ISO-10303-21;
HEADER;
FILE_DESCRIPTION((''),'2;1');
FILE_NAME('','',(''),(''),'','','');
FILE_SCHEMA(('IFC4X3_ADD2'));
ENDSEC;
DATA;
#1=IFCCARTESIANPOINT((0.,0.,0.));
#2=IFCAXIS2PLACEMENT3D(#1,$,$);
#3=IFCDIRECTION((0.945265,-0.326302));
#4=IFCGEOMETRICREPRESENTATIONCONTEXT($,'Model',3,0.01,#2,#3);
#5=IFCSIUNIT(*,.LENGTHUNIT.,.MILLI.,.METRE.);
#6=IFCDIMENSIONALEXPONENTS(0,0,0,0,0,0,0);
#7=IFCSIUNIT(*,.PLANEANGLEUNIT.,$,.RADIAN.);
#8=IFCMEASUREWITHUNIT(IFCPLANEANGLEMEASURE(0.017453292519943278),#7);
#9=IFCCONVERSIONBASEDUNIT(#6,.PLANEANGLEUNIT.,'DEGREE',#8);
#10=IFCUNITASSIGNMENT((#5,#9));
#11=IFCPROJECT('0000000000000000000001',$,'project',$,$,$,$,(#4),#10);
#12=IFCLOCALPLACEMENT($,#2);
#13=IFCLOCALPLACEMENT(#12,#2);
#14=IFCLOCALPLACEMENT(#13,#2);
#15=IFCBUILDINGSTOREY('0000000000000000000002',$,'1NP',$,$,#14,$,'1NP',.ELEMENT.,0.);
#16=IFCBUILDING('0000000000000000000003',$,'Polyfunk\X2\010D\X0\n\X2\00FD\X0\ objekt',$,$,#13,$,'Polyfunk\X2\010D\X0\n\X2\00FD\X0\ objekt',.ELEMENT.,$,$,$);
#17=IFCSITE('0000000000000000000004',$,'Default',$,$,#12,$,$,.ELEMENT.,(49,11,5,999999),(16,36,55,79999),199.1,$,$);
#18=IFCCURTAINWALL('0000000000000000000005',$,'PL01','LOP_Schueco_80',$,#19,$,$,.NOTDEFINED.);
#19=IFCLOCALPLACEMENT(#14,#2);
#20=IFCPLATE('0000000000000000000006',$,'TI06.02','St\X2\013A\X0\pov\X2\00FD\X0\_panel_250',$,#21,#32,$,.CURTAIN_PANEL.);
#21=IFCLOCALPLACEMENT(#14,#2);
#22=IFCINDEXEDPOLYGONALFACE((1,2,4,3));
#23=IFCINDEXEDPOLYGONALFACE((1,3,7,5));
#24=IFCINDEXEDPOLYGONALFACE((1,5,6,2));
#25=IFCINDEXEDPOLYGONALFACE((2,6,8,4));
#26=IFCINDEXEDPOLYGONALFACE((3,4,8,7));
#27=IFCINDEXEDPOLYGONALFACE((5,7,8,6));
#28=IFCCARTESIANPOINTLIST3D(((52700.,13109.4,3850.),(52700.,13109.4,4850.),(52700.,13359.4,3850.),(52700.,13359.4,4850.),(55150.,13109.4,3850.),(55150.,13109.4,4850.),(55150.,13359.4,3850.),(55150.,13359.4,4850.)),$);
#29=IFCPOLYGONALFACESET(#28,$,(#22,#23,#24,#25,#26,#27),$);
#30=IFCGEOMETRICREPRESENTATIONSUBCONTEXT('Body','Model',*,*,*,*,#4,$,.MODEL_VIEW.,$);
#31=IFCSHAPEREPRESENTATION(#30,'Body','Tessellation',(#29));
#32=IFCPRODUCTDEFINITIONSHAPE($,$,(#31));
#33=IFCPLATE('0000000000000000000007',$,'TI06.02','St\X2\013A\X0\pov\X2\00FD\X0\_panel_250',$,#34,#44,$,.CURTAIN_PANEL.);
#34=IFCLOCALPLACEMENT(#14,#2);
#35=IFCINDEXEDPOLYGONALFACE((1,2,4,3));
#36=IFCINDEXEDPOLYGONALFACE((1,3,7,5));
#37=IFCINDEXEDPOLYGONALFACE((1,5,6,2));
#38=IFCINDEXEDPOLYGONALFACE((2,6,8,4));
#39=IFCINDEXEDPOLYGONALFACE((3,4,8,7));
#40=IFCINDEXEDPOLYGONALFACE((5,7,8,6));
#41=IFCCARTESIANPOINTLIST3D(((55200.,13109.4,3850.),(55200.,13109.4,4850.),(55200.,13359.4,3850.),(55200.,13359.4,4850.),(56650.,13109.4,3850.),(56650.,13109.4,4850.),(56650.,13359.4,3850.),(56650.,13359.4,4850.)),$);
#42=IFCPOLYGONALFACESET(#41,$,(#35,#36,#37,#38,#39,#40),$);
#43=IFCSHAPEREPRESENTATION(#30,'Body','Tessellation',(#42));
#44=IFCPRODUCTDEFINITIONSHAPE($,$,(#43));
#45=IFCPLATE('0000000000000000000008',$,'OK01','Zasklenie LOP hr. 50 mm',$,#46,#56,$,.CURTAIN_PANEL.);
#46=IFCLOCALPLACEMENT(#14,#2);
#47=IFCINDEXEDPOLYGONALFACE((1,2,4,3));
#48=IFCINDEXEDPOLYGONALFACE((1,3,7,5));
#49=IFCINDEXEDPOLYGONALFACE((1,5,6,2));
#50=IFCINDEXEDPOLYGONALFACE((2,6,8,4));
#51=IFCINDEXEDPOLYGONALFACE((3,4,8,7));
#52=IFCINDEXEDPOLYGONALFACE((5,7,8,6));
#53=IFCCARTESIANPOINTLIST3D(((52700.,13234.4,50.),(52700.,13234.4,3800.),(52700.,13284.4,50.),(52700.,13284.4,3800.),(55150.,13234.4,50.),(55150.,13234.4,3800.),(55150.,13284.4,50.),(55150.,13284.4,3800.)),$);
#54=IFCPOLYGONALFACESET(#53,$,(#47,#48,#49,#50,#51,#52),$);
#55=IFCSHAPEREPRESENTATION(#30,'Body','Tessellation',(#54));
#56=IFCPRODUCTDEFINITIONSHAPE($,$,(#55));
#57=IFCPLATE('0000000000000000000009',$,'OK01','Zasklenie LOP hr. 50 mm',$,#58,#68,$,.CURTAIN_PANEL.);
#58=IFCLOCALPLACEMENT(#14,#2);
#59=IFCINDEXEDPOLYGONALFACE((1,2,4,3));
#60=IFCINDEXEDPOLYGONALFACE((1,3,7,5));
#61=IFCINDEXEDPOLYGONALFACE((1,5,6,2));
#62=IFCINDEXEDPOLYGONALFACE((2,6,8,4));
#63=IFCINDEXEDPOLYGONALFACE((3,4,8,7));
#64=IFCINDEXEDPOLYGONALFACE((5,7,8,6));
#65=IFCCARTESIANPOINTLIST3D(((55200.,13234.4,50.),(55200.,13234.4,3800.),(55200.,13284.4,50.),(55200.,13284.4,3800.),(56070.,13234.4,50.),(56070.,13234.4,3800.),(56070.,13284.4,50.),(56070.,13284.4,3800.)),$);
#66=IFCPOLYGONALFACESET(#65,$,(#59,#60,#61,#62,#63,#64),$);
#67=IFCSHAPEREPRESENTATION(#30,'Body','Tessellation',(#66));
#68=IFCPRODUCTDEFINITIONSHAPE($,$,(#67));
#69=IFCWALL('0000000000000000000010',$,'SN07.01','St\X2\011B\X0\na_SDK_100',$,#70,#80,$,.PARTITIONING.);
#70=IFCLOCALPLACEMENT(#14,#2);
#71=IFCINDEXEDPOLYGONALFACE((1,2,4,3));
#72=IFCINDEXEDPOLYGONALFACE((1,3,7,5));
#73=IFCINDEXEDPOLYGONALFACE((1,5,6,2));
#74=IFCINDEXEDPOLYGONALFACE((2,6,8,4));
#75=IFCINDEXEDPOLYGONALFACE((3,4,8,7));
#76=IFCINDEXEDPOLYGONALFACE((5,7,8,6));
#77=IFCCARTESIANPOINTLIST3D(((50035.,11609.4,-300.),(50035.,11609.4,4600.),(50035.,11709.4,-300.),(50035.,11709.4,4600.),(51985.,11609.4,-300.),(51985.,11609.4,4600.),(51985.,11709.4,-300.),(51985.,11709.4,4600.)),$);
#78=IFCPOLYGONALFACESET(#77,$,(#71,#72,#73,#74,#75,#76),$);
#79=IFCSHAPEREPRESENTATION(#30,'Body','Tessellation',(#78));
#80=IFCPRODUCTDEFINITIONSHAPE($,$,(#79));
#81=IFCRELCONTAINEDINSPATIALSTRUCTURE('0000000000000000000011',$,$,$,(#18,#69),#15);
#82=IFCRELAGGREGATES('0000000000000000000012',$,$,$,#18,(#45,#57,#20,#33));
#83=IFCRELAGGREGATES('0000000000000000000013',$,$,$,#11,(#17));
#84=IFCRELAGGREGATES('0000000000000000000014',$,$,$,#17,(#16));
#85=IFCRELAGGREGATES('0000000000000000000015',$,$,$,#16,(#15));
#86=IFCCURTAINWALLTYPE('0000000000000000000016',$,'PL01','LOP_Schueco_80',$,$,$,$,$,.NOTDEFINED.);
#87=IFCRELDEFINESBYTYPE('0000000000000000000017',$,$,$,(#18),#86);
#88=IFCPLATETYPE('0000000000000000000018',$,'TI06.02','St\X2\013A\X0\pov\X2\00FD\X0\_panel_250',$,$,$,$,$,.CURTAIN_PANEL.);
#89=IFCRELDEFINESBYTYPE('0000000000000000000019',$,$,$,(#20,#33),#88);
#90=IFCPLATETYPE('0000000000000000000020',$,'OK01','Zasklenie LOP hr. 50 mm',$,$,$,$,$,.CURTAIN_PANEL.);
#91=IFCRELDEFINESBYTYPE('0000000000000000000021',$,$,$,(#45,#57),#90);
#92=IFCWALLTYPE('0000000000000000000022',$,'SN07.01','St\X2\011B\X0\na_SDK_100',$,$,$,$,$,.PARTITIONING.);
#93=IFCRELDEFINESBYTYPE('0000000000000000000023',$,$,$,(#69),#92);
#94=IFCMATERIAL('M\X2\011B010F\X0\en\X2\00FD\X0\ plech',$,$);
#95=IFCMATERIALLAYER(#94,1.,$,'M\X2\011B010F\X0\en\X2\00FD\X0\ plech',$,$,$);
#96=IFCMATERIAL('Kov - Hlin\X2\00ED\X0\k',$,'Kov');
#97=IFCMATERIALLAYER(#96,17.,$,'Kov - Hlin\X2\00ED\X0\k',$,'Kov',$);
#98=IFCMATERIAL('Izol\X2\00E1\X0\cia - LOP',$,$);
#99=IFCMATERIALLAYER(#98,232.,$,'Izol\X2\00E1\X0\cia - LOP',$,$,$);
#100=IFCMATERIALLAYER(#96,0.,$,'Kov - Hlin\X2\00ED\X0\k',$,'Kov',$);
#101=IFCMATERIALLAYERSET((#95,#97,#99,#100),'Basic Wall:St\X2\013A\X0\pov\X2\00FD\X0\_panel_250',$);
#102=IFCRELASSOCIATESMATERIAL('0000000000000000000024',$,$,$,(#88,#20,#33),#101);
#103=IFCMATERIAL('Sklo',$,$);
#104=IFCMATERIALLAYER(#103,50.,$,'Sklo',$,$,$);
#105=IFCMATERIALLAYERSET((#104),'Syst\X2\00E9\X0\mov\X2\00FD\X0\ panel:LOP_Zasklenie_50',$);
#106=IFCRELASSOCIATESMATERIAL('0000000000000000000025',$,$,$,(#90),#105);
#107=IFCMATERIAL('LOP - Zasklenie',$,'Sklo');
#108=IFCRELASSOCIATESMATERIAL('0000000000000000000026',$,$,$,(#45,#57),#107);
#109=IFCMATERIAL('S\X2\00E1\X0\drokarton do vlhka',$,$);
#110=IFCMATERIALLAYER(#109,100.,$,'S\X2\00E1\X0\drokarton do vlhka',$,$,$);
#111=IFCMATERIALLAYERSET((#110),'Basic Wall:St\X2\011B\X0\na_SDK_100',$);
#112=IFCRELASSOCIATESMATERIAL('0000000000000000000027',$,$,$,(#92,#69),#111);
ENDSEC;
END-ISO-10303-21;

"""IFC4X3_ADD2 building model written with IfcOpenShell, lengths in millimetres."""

from ifc_helpers import new_model, entity, si_unit, converted_unit, direction, frame, frame_2d, origin, origin_2d_with_axis, place, context, subcontext, project, spatial, polyline, rectangle, extrude, clip, bounded_halfspace, source, transform, mapped, material, layer, layer_set, layer_usage, type_object, type_shapes, element, aggregate, save


model = new_model("IFC4X3_ADD2")

# Units and contexts
model_context = context("Model", 3, precision=0.01, world=origin(), true_north=direction((0.945265, -0.326302)))
body_context = subcontext(model_context, "Body", "Model", "MODEL_VIEW")
ifc_project = project(units=[si_unit("LENGTHUNIT", "METRE", prefix="MILLI"), converted_unit("PLANEANGLEUNIT", "DEGREE", entity("IfcPlaneAngleMeasure", 0.017453292519943278), si_unit("PLANEANGLEUNIT", "RADIAN"), dimensions=[0, 0, 0, 0, 0, 0, 0])], contexts=[model_context])

# Site, building, storey
site_placement = place(None, origin())
site = spatial("IfcSite", under=ifc_project, at=site_placement, Name="Default", CompositionType="ELEMENT", RefLatitude=(49, 11, 5, 999999), RefLongitude=(16, 36, 55, 79999), RefElevation=199.1)
building_placement = place(site_placement, origin())
building = spatial("IfcBuilding", under=site, at=building_placement, Name="Polyfunkčný objekt", LongName="Polyfunkčný objekt", CompositionType="ELEMENT")
storey_placement = place(building_placement, origin())
storey = spatial("IfcBuildingStorey", under=building, at=storey_placement, Name="1NP", LongName="1NP", CompositionType="ELEMENT", Elevation=0.0)

# Curtain wall, plates
curtain_wall_type = type_object("IfcCurtainWallType", Name="PL01", Description="LOP_Schueco_80", PredefinedType="NOTDEFINED")
curtain_wall_placement = place(storey_placement, origin())
curtain_wall = element("IfcCurtainWall", 1, at=curtain_wall_placement, inside=storey, type_object=curtain_wall_type, Name="PL01", Description="LOP_Schueco_80", PredefinedType="NOTDEFINED")
ifc_material_1 = material(Name="Měďený plech")
ifc_layer_1 = layer(ifc_material_1, 1.0, Name="Měďený plech")
ifc_material_2 = material(Name="Kov - Hliník", Category="Kov")
ifc_layer_2 = layer(ifc_material_2, 17.0, Name="Kov - Hliník", Category="Kov")
ifc_material_3 = material(Name="Izolácia - LOP")
ifc_layer_3 = layer(ifc_material_3, 232.0, Name="Izolácia - LOP")
ifc_layer_4 = layer(ifc_material_2, 0.0, Name="Kov - Hliník", Category="Kov")
ifc_layer_set_1 = layer_set([ifc_layer_1, ifc_layer_2, ifc_layer_3, ifc_layer_4], Name="Basic Wall:Stĺpový_panel_250")
ifc_layer_usage_1 = layer_usage(ifc_layer_set_1, "AXIS2", "NEGATIVE", 125.0)
plate_type_1 = type_object("IfcPlateType", Name="TI06.02", Description="Stĺpový_panel_250", PredefinedType="CURTAIN_PANEL", material=ifc_layer_set_1)
plate_1_placement = place(storey_placement, frame((52700.0, 13234.4, 3850.0)))
plate_1 = element("IfcPlate", 2, at=plate_1_placement, type_object=plate_type_1, material=ifc_layer_usage_1, Name="TI06.02", Description="Stĺpový_panel_250", PredefinedType="CURTAIN_PANEL", context=body_context, shape_type="SweptSolid", body=[
    extrude(rectangle(XDim=250.0, YDim=2450.0, at=origin_2d_with_axis()), frame((1225.0, 0.0, 0.0), z_axis=(0.0, 0.0, 1.0), x_axis=(0.0, 1.0, 0.0)), (0.0, 0.0, 1.0), 1000.0),
])
ifc_layer_usage_2 = layer_usage(ifc_layer_set_1, "AXIS2", "NEGATIVE", 125.0)
plate_2_placement = place(storey_placement, frame((55200.0, 13234.4, 3850.0)))
plate_2 = element("IfcPlate", 3, at=plate_2_placement, type_object=plate_type_1, material=ifc_layer_usage_2, Name="TI06.02", Description="Stĺpový_panel_250", PredefinedType="CURTAIN_PANEL", context=body_context, shape_type="SweptSolid", body=[
    extrude(rectangle(XDim=250.0, YDim=1450.0, at=origin_2d_with_axis()), frame((725.0, 0.0, 0.0), z_axis=(0.0, 0.0, 1.0), x_axis=(0.0, 1.0, 0.0)), (0.0, 0.0, 1.0), 1000.0),
])
ifc_material_4 = material(Name="LOP - Zasklenie", Category="Sklo")
ifc_material_5 = material(Name="Sklo")
ifc_layer_5 = layer(ifc_material_5, 50.0, Name="Sklo")
ifc_layer_set_2 = layer_set([ifc_layer_5], Name="Systémový panel:LOP_Zasklenie_50")
plate_type_2 = type_object("IfcPlateType", Name="OK01", Description="Zasklenie LOP hr. 50 mm", PredefinedType="CURTAIN_PANEL", material=ifc_layer_set_2)
shared_shape_1 = source(origin(), body_context, "Body", "SweptSolid", [
    extrude(rectangle(XDim=3750.0, YDim=2450.0, at=frame_2d((-141.7, 0.0), x_axis=(1.0, 0.0))), frame((0.0, 0.0, 2016.7), z_axis=(0.0, 1.0, 0.0), x_axis=(0.0, 0.0, 1.0)), (0.0, 0.0, 1.0), 50.0),
])
plate_3_placement = place(curtain_wall_placement, frame((53925.0, 13234.4, 50.0)))
plate_3 = element("IfcPlate", 4, at=plate_3_placement, type_object=plate_type_2, material=ifc_material_4, Name="OK01", Description="Zasklenie LOP hr. 50 mm", PredefinedType="CURTAIN_PANEL", context=body_context, shape_type="MappedRepresentation", body=[
    mapped(shared_shape_1, transform((0.0, 0.0, 0.0), scale=1.0)),
])
shared_shape_2 = source(origin(), body_context, "Body", "SweptSolid", [
    extrude(rectangle(XDim=3750.0, YDim=870.0, at=frame_2d((-141.7, 0.0), x_axis=(1.0, 0.0))), frame((0.0, 0.0, 2016.7), z_axis=(0.0, 1.0, 0.0), x_axis=(0.0, 0.0, 1.0)), (0.0, 0.0, 1.0), 50.0),
])
type_shapes(plate_type_2, [shared_shape_1, shared_shape_2])
plate_4_placement = place(curtain_wall_placement, frame((55635.0, 13234.4, 50.0)))
plate_4 = element("IfcPlate", 5, at=plate_4_placement, type_object=plate_type_2, material=ifc_material_4, Name="OK01", Description="Zasklenie LOP hr. 50 mm", PredefinedType="CURTAIN_PANEL", context=body_context, shape_type="MappedRepresentation", body=[
    mapped(shared_shape_2, transform((0.0, 0.0, 0.0), scale=1.0)),
])
aggregate(curtain_wall, [plate_3, plate_4, plate_1, plate_2])

# Wall
ifc_material_6 = material(Name="Sádrokarton do vlhka")
ifc_layer_6 = layer(ifc_material_6, 100.0, Name="Sádrokarton do vlhka")
ifc_layer_set_3 = layer_set([ifc_layer_6], Name="Basic Wall:Stěna_SDK_100")
wall_type = type_object("IfcWallType", Name="SN07.01", Description="Stěna_SDK_100", PredefinedType="PARTITIONING", material=ifc_layer_set_3)
wall_placement = place(storey_placement, frame((51985.0, 11659.4, -300.0), z_axis=(0.0, 0.0, 1.0), x_axis=(-1.0, 0.0, 0.0)))
element("IfcWall", 6, at=wall_placement, inside=storey, type_object=wall_type, material=ifc_layer_set_3, Name="SN07.01", Description="Stěna_SDK_100", PredefinedType="PARTITIONING", context=body_context, shape_type="Clipping", body=[
    clip(clip(extrude(rectangle(XDim=1950.0, YDim=100.0, at=frame_2d((975.0, 0.0), x_axis=(-1.0, 0.0))), origin(), (0.0, 0.0, 1.0), 4900.0), bounded_halfspace(frame((0.0, -50.0, 4900.0), z_axis=(0.0, 0.0, -1.0), x_axis=(-1.0, 0.0, 0.0)), True, frame((0.0, -50.0, 4900.0)), polyline([(0.0, 0.0), (1950.0, 0.0), (1950.0, 100.0), (1050.0, 100.0), (900.0, 100.0), (0.0, 100.0), (0.0, 0.0)]))), bounded_halfspace(frame((1950.0, -50.0, 0.0), z_axis=(0.0, 0.0, 1.0), x_axis=(0.0, -1.0, 0.0)), True, frame((1950.0, -50.0, 0.0)), polyline([(0.0, 0.0), (0.0, 100.0), (-900.0, 100.0), (-1050.0, 100.0), (-1950.0, 100.0), (-1950.0, 0.0), (0.0, 0.0)]))),
])

save(model, "model.ifc")
